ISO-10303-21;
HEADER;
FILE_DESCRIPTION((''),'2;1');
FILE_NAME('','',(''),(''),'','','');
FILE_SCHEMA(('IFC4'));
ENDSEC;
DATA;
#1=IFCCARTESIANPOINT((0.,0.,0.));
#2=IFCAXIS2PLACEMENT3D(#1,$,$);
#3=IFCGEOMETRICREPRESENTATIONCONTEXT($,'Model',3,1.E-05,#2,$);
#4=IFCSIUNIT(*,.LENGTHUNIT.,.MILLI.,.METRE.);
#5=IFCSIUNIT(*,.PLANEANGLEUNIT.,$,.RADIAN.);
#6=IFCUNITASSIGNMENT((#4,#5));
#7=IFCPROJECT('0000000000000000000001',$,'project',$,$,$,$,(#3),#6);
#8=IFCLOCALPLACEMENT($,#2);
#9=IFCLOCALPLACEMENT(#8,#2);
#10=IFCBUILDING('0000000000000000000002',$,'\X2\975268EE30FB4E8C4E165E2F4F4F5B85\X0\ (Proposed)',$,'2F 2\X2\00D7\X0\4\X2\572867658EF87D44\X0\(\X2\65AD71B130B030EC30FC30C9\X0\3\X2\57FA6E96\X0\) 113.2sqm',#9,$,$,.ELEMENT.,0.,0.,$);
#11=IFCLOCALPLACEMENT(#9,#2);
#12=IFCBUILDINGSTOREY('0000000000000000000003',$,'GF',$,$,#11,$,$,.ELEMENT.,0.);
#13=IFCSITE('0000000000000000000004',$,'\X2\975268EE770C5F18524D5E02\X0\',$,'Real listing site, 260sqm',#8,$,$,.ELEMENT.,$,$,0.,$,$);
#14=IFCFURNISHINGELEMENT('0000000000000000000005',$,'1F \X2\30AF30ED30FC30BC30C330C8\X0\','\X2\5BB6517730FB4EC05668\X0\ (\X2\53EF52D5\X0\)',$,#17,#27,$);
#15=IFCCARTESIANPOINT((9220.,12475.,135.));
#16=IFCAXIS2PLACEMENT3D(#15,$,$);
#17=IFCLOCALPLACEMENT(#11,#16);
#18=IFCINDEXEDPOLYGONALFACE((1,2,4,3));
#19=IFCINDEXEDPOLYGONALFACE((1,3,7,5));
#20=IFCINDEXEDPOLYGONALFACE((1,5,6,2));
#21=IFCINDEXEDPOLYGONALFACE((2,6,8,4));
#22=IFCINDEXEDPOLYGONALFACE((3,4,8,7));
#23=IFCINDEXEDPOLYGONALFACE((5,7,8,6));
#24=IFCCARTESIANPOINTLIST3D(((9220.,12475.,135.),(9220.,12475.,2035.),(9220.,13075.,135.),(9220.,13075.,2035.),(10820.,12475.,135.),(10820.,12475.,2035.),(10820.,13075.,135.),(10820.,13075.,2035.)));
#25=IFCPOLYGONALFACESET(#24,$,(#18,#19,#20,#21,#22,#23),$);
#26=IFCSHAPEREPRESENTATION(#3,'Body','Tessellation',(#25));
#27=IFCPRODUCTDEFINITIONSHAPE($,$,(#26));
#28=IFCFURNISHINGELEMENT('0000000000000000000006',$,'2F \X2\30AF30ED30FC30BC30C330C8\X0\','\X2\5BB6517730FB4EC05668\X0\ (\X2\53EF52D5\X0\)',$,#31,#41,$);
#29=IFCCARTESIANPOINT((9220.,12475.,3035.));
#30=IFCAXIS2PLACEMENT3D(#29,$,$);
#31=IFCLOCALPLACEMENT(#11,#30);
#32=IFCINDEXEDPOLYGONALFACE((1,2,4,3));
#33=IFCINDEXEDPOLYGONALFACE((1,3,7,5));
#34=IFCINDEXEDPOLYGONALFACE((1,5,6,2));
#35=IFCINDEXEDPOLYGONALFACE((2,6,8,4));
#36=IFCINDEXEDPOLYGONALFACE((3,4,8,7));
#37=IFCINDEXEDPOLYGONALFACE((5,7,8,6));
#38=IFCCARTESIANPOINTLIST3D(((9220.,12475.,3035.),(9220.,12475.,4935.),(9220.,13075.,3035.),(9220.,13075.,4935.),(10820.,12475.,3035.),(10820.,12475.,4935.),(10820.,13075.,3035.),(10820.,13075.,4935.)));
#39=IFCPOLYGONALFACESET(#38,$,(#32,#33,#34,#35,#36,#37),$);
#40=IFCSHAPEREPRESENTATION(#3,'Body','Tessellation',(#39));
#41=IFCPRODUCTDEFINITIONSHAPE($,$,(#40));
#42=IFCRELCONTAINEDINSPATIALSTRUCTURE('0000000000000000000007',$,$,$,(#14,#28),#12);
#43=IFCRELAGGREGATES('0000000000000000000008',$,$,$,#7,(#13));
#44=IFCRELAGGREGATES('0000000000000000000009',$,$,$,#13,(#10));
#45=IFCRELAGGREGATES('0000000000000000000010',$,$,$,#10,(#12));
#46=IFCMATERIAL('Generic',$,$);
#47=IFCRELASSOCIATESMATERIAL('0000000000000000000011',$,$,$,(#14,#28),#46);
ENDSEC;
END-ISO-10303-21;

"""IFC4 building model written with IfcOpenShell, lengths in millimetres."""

from ifc_helpers import new_model, si_unit, frame, frame_2d, origin, place, context, project, spatial, rectangle, extrude, material, element, save


model = new_model("IFC4")

# Units and contexts
model_context = context("Model", 3, precision=1e-05, world=origin())
ifc_project = project(units=[si_unit("LENGTHUNIT", "METRE", prefix="MILLI"), si_unit("PLANEANGLEUNIT", "RADIAN")], contexts=[model_context])

# Site, building, storey
site_placement = place(None, origin())
site = spatial("IfcSite", under=ifc_project, at=site_placement, Name="青森県弘前市", ObjectType="Real listing site, 260sqm", CompositionType="ELEMENT", RefElevation=0.0)
building_placement = place(site_placement, origin())
building = spatial("IfcBuilding", under=site, at=building_placement, Name="青森・二世帯住宅 (Proposed)", ObjectType="2F 2×4在来軸組(断熱グレード3基準) 113.2sqm", CompositionType="ELEMENT", ElevationOfRefHeight=0.0, ElevationOfTerrain=0.0)
storey_placement = place(building_placement, origin())
storey = spatial("IfcBuildingStorey", under=building, at=storey_placement, Name="GF", CompositionType="ELEMENT", Elevation=0.0)

# Shared definitions
ifc_material_1 = material(Name="Generic")

# Furnishing elements
furnishing_1_placement = place(storey_placement, frame((9220.0, 12475.0, 135.0)))
element("IfcFurnishingElement", 1, at=furnishing_1_placement, inside=storey, material=ifc_material_1, Name="1F クローゼット", Description="家具・什器 (可動)", context=model_context, shape_type="SweptSolid", body=[
    extrude(rectangle(XDim=1600.0, YDim=600.0, at=frame_2d((800.0, 300.0))), frame((9220.0, 12475.0, 135.0)), (0.0, 0.0, 1.0), 1900.0),
])
furnishing_2_placement = place(storey_placement, frame((9220.0, 12475.0, 3035.0)))
element("IfcFurnishingElement", 2, at=furnishing_2_placement, inside=storey, material=ifc_material_1, Name="2F クローゼット", Description="家具・什器 (可動)", context=model_context, shape_type="SweptSolid", body=[
    extrude(rectangle(XDim=1600.0, YDim=600.0, at=frame_2d((800.0, 300.0))), frame((9220.0, 12475.0, 3035.0)), (0.0, 0.0, 1.0), 1900.0),
])

save(model, "model.ifc")
